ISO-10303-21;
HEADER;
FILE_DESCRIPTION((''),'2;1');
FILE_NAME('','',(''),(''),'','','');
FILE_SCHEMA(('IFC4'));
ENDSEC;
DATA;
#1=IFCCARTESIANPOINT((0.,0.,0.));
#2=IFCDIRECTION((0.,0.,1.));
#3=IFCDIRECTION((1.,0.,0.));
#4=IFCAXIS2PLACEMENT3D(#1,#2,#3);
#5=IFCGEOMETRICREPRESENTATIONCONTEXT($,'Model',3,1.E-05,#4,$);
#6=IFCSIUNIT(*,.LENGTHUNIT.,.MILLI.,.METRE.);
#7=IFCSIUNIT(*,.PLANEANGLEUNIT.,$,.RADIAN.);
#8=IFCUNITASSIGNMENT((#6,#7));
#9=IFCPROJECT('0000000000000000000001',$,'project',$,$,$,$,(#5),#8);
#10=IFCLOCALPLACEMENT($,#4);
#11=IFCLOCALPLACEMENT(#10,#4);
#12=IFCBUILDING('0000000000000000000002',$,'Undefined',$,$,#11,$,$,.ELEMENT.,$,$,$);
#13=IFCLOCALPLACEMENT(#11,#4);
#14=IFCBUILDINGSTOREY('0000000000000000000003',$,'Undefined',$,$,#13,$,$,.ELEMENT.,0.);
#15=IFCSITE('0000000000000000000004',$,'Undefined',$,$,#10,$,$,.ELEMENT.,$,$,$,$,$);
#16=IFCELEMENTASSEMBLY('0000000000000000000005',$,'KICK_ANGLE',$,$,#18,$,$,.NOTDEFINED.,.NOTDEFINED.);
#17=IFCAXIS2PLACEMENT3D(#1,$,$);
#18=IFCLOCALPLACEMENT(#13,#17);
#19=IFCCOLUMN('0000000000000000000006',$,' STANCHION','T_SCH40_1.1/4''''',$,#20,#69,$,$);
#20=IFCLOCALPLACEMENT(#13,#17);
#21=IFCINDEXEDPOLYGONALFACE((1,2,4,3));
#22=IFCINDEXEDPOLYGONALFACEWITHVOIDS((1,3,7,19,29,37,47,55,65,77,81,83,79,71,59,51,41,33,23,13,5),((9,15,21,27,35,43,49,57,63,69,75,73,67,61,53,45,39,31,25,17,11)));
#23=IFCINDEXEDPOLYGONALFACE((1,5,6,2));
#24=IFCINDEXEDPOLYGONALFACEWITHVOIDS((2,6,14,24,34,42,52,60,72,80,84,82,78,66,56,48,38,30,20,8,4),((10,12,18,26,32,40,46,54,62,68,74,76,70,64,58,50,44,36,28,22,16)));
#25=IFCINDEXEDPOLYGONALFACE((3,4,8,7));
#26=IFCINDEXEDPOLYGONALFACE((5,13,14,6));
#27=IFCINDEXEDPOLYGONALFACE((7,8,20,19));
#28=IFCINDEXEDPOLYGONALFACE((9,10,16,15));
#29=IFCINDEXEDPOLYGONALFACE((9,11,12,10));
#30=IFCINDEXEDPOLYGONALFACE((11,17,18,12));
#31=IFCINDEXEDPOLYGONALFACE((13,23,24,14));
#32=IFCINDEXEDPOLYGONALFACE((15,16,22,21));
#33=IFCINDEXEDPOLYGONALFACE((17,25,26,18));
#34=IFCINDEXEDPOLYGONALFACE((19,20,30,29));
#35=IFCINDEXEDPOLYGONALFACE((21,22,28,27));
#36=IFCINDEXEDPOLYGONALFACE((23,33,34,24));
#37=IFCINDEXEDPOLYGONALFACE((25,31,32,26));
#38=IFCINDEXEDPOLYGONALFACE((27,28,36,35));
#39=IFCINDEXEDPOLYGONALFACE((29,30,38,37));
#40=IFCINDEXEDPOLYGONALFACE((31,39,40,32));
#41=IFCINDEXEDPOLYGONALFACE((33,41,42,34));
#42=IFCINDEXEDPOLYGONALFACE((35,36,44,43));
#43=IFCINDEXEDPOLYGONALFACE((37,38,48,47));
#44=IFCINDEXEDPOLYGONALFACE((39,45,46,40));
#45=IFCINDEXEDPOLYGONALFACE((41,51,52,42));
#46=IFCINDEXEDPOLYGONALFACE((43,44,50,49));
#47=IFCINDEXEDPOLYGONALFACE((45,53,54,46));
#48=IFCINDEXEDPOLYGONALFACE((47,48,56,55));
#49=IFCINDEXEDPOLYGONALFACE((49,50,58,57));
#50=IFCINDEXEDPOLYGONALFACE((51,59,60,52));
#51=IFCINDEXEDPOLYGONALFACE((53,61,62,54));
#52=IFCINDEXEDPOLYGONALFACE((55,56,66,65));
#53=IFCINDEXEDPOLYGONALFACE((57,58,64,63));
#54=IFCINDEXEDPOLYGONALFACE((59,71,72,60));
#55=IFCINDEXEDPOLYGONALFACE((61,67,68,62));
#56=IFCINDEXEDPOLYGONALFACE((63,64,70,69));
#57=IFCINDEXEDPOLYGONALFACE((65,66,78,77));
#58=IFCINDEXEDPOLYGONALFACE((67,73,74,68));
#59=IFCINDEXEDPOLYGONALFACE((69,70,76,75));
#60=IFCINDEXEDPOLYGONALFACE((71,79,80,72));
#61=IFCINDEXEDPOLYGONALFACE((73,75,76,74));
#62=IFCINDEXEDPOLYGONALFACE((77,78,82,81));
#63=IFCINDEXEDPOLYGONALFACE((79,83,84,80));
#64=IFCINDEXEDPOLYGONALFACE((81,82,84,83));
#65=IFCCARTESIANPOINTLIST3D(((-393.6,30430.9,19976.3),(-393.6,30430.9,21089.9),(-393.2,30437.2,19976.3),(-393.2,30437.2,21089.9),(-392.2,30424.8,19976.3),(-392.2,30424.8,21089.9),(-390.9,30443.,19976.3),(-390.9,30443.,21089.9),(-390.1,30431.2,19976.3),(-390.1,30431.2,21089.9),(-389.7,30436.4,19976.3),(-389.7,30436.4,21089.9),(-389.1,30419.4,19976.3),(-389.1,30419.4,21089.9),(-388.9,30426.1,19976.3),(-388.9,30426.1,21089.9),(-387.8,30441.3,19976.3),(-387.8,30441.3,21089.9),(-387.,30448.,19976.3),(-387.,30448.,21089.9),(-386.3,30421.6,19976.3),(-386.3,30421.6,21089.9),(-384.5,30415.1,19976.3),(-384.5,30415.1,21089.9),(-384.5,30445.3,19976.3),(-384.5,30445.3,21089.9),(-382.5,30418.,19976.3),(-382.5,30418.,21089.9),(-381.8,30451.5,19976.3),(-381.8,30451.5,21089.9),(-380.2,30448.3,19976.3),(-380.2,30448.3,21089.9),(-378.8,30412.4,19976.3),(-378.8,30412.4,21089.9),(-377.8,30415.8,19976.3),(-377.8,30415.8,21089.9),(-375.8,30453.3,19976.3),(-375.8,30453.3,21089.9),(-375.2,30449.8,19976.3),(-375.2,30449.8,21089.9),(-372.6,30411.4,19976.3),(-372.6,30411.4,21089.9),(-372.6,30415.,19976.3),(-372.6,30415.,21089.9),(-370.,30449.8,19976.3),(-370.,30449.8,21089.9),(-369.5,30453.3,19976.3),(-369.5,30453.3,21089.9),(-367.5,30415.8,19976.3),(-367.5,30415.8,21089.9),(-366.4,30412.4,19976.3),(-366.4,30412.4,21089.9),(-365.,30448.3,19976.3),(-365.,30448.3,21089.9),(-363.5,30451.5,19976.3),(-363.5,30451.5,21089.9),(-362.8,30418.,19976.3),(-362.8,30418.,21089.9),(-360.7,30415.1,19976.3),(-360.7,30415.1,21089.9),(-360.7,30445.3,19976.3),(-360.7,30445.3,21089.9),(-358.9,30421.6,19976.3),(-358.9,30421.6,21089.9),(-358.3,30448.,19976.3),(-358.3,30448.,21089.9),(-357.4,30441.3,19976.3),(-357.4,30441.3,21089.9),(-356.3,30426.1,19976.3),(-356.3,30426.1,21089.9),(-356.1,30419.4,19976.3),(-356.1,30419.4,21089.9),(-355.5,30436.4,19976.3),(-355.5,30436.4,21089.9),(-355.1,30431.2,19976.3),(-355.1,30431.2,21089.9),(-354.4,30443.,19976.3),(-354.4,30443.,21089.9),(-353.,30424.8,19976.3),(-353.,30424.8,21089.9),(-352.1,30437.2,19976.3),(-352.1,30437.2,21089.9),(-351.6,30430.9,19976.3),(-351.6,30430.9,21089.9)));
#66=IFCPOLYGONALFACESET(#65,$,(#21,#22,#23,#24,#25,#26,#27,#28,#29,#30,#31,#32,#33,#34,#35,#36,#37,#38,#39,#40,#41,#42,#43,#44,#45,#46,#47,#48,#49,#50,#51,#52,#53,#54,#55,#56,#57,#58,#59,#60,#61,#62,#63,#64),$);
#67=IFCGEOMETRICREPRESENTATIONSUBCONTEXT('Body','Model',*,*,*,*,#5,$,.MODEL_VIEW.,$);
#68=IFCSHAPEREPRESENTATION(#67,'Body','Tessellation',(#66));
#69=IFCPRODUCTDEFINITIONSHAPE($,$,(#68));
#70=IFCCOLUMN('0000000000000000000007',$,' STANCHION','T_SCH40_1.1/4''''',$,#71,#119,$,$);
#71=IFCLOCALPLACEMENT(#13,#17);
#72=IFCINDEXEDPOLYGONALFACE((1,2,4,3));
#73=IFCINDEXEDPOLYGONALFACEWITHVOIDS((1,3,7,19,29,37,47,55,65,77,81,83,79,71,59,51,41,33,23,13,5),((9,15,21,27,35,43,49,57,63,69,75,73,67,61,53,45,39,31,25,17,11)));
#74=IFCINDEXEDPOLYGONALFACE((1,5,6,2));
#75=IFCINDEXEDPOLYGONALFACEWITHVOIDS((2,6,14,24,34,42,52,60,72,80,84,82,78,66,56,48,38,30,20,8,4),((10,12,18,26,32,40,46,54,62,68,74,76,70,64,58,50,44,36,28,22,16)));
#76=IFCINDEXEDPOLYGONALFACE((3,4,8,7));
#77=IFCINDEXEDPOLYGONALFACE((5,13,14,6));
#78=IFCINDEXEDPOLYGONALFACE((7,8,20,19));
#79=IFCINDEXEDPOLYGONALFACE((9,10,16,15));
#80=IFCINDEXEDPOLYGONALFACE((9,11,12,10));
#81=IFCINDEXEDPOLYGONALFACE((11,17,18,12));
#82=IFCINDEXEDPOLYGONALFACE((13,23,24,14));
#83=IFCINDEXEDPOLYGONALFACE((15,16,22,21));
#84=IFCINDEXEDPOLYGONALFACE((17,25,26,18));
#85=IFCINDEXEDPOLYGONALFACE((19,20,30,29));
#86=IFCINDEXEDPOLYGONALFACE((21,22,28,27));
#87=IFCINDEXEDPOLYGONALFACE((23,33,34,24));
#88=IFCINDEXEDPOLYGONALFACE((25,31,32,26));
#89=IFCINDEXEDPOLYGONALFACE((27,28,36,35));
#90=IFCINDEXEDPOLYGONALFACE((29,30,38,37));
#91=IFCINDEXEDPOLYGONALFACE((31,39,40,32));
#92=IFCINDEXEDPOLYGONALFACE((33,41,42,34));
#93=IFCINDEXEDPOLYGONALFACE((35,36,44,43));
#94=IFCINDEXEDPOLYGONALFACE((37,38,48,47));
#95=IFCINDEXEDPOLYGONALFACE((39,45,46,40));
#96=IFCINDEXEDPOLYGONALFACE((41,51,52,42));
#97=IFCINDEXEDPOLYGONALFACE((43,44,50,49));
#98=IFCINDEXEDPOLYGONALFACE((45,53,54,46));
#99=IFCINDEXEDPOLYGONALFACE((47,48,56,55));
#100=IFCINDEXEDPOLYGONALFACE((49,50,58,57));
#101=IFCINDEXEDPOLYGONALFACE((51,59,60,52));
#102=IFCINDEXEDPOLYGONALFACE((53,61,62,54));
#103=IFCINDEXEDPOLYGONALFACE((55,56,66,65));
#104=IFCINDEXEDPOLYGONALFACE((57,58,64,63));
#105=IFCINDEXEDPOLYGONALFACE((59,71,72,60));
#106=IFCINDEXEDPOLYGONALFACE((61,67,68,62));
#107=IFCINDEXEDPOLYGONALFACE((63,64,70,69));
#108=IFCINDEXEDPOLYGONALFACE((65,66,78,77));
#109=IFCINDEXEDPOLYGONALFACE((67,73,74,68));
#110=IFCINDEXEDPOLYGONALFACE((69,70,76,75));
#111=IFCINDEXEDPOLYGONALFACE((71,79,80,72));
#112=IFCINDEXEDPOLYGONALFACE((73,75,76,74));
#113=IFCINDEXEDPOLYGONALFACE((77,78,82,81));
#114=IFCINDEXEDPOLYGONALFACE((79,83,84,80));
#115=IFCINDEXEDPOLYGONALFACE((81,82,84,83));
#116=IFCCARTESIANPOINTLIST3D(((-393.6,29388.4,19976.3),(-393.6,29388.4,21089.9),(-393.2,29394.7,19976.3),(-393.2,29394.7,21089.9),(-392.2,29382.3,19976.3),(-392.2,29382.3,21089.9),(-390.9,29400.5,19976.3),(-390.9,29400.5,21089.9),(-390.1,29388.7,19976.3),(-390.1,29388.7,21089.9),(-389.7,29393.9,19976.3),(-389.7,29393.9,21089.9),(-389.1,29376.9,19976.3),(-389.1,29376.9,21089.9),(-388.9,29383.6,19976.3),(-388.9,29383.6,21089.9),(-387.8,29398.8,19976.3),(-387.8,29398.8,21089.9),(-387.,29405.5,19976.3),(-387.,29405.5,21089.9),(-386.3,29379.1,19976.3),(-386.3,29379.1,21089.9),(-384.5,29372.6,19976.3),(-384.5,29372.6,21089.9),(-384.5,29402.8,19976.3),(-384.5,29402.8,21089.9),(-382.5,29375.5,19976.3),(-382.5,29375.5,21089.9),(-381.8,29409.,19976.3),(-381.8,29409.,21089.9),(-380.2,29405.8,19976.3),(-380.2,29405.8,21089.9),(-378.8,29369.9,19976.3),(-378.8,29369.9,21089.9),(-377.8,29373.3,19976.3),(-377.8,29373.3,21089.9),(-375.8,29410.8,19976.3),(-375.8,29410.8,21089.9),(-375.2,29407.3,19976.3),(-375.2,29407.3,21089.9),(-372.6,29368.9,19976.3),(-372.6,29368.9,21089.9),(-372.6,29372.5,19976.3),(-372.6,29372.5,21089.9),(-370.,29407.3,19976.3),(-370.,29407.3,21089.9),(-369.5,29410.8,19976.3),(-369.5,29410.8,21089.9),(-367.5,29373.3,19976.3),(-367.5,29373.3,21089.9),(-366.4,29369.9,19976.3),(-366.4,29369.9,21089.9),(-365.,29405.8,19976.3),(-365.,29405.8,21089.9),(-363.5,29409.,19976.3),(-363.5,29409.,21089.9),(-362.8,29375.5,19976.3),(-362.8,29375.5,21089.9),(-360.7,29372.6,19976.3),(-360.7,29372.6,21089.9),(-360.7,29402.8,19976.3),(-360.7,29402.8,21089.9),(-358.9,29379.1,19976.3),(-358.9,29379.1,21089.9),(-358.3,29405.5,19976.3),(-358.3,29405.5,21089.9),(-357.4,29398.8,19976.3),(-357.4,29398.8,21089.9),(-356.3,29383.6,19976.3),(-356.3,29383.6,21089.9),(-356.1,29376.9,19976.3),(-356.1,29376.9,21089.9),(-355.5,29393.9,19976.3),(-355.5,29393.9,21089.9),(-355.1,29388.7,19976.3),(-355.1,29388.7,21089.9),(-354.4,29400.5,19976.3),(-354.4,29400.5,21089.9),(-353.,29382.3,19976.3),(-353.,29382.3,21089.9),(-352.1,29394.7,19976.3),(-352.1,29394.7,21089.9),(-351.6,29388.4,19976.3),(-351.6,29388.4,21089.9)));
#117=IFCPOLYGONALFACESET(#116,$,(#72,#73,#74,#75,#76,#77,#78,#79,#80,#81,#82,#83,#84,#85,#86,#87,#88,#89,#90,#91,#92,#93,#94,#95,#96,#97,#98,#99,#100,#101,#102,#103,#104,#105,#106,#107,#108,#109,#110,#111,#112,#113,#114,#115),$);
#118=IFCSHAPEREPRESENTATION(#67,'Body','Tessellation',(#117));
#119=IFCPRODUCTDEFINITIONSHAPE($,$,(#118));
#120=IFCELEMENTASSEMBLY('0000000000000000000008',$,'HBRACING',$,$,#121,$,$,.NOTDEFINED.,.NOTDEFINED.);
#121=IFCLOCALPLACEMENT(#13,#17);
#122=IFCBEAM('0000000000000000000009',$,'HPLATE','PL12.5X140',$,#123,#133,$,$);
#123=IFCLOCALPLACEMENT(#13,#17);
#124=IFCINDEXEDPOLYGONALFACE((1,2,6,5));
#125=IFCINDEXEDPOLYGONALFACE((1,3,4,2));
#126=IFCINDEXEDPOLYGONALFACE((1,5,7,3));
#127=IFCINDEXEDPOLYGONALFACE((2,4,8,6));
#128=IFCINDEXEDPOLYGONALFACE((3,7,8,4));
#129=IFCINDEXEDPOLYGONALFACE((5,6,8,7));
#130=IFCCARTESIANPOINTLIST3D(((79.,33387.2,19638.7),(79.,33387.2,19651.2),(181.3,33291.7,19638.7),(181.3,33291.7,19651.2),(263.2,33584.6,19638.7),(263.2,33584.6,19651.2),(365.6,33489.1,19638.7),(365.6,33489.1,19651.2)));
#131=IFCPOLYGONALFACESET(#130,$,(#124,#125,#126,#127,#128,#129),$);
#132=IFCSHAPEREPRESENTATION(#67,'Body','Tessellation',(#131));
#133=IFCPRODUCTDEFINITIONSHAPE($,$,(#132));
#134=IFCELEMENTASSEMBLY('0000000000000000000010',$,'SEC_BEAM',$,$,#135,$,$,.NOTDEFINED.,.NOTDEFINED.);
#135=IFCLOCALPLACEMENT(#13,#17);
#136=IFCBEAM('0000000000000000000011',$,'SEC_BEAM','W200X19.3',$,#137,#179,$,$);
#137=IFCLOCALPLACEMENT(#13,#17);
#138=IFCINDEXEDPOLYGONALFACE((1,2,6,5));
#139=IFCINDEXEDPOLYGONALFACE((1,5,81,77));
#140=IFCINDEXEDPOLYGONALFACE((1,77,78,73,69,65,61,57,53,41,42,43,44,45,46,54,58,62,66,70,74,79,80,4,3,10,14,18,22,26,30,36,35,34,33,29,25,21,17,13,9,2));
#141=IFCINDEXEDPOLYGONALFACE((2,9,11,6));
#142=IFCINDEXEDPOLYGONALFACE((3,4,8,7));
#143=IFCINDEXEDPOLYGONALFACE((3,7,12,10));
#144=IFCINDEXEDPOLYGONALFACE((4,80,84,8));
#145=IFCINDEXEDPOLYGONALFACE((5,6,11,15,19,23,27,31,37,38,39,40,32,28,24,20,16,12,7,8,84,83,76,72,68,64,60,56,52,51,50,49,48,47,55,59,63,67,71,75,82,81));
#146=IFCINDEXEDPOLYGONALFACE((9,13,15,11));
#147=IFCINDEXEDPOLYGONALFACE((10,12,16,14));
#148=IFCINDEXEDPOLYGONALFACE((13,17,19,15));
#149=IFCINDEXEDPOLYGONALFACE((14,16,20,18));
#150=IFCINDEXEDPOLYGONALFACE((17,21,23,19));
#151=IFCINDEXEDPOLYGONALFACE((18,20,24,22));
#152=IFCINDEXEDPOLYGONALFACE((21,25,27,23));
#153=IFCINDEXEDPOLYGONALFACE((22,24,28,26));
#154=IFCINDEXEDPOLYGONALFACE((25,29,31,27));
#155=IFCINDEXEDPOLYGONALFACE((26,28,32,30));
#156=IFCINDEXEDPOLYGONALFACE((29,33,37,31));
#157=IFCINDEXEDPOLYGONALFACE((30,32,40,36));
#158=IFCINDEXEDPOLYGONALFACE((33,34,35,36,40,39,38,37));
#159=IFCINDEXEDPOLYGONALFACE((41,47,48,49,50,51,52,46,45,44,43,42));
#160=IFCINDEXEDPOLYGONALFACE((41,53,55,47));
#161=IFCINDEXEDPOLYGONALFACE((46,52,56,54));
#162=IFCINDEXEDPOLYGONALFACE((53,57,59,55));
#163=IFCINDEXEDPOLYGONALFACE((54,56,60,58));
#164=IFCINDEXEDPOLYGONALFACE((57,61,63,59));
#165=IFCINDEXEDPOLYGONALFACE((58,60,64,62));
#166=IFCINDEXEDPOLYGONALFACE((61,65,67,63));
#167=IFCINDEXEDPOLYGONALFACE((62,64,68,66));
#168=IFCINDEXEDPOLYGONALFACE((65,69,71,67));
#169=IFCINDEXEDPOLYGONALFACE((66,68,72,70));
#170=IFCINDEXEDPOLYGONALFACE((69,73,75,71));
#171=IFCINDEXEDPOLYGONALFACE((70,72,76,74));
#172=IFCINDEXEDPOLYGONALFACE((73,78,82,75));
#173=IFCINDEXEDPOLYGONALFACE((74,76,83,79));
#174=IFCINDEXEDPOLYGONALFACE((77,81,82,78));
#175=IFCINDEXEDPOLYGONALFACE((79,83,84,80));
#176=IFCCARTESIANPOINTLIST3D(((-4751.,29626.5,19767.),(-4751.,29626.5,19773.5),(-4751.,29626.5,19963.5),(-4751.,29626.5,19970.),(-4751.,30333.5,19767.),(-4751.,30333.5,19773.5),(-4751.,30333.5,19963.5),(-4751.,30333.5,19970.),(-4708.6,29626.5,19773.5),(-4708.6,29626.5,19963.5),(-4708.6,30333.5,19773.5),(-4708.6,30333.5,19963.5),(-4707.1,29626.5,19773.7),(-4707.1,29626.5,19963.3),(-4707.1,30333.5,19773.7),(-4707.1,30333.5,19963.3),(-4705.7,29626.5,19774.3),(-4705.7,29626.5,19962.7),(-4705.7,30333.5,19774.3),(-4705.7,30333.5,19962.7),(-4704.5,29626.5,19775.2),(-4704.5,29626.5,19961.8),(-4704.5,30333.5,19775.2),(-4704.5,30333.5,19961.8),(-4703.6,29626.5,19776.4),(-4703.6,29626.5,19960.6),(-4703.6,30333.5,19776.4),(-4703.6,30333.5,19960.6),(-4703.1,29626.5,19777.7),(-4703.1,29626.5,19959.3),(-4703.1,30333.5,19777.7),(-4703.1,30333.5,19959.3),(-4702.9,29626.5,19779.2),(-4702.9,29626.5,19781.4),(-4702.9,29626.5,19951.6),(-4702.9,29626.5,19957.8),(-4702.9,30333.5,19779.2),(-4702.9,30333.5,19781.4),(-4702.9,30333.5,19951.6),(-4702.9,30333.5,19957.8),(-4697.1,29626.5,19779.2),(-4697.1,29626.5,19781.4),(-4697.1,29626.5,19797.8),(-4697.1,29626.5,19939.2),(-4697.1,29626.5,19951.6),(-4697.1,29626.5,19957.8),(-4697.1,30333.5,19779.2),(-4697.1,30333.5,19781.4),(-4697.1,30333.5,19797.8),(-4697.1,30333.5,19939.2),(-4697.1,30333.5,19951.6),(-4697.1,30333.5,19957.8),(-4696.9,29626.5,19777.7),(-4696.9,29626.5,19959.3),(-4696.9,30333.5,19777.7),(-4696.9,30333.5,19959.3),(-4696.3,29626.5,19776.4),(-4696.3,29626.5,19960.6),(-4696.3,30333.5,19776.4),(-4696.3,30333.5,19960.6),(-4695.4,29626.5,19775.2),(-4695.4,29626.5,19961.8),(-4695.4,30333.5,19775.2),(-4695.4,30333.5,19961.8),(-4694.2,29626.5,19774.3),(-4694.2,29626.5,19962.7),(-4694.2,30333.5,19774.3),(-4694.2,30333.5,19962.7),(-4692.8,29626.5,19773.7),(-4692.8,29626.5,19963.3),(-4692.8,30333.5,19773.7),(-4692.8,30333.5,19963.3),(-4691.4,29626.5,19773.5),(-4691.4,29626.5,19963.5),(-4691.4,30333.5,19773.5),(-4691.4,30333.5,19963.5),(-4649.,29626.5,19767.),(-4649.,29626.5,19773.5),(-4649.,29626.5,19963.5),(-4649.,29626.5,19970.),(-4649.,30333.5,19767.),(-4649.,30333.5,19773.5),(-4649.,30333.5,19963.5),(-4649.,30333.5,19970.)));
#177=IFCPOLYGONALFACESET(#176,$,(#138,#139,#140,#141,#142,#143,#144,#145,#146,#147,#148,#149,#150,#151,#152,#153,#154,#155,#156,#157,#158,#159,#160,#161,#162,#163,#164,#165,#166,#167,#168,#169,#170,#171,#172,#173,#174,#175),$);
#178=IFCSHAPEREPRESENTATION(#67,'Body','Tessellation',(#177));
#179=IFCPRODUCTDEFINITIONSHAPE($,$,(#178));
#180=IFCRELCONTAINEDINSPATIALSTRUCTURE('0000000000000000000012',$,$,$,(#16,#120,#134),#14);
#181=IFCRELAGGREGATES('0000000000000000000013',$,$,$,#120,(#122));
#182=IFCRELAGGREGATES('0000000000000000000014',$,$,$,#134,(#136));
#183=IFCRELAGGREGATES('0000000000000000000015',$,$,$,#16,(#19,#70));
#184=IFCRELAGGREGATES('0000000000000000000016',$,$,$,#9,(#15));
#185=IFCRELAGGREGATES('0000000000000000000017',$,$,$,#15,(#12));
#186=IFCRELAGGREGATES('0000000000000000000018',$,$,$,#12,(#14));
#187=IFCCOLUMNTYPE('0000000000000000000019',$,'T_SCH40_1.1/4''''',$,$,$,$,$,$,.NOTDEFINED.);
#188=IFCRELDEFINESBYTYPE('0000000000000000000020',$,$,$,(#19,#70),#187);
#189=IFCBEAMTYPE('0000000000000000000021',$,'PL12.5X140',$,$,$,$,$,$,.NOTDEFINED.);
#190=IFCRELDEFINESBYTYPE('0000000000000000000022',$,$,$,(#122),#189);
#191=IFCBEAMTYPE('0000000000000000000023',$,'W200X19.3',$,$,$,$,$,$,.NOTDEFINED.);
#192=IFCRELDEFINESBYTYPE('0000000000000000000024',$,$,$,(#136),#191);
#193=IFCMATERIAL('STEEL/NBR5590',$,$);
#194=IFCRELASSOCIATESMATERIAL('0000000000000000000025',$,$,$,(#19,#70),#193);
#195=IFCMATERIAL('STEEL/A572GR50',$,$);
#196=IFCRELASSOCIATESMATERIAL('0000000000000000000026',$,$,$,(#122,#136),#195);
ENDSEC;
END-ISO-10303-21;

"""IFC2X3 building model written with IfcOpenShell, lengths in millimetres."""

from ifc_helpers import new_model, si_unit, frame, origin_with_axes, origin_2d_with_axis, place, context, subcontext, project, spatial, polyline, rectangle, hollow_circle, i_section, outline, extrude, boolean, halfspace, material, type_object, element, aggregate, save


model = new_model("IFC2X3")

# Units and contexts
model_context = context("Model", 3, precision=1e-05, world=origin_with_axes())
body_context = subcontext(model_context, "Body", "Model", "MODEL_VIEW")
ifc_project = project(units=[si_unit("LENGTHUNIT", "METRE", prefix="MILLI"), si_unit("PLANEANGLEUNIT", "RADIAN")], contexts=[model_context])

# Site, building, storey
site_placement = place(None, origin_with_axes())
site = spatial("IfcSite", under=ifc_project, at=site_placement, Name="Undefined", CompositionType="ELEMENT")
building_placement = place(site_placement, origin_with_axes())
building = spatial("IfcBuilding", under=site, at=building_placement, Name="Undefined", CompositionType="ELEMENT")
storey_placement = place(building_placement, origin_with_axes())
storey = spatial("IfcBuildingStorey", under=building, at=storey_placement, Name="Undefined", CompositionType="ELEMENT", Elevation=0.0)

# Shared definitions
ifc_material_1 = material(Name="STEEL/NBR5590")
column_type = type_object("IfcColumnType", Name="T_SCH40_1.1/4''", PredefinedType="NOTDEFINED")

# Element assembly, columns
assembly_1_placement = place(storey_placement, origin_with_axes())
assembly_1 = element("IfcElementAssembly", 1, at=assembly_1_placement, inside=storey, Name="KICK_ANGLE", AssemblyPlace="NOTDEFINED", PredefinedType="NOTDEFINED")
column_1_placement = place(assembly_1_placement, frame((-372.6, 30432.5, 19976.3), z_axis=(0.0, 0.0, 1.0), x_axis=(-1.0, 0.0, 0.0)))
column_1 = element("IfcColumn", 2, at=column_1_placement, type_object=column_type, material=ifc_material_1, Name=" STANCHION", Description="T_SCH40_1.1/4''", context=body_context, shape_type="SweptSolid", body=[
    extrude(hollow_circle(Radius=21.1, WallThickness=3.6, at=origin_2d_with_axis()), frame((0.0, 0.0, 1113.6), z_axis=(0.0, 0.0, -1.0), x_axis=(0.0, 1.0, 0.0)), (0.0, 0.0, 1.0), 1113.6),
])
column_2_placement = place(assembly_1_placement, frame((-372.6, 29390.0, 19976.3), z_axis=(0.0, 0.0, 1.0), x_axis=(-1.0, 0.0, 0.0)))
column_2 = element("IfcColumn", 3, at=column_2_placement, type_object=column_type, material=ifc_material_1, Name=" STANCHION", Description="T_SCH40_1.1/4''", context=body_context, shape_type="SweptSolid", body=[
    extrude(hollow_circle(Radius=21.1, WallThickness=3.6, at=origin_2d_with_axis()), frame((0.0, 0.0, 1113.6), z_axis=(0.0, 0.0, -1.0), x_axis=(0.0, 1.0, 0.0)), (0.0, 0.0, 1.0), 1113.6),
])

# Element assemblies, beams
assembly_2_placement = place(storey_placement, origin_with_axes())
assembly_2 = element("IfcElementAssembly", 4, at=assembly_2_placement, inside=storey, Name="HBRACING", AssemblyPlace="NOTDEFINED", PredefinedType="NOTDEFINED")
ifc_material_2 = material(Name="STEEL/A572GR50")
beam_type_1 = type_object("IfcBeamType", Name="PL12.5X140", PredefinedType="NOTDEFINED")
beam_1_placement = place(assembly_2_placement, frame((130.2, 33339.5, 19645.0), z_axis=(0.731055, -0.682318, 0.0), x_axis=(0.682318, 0.731055, 0.0)))
beam_1 = element("IfcBeam", 5, at=beam_1_placement, type_object=beam_type_1, material=ifc_material_2, Name="HPLATE", Description="PL12.5X140", context=body_context, shape_type="SweptSolid", body=[
    extrude(rectangle(XDim=12.5, YDim=140.0, at=origin_2d_with_axis()), frame((270.0, 0.0, 0.0), z_axis=(-1.0, 0.0, 0.0), x_axis=(0.0, -1.0, 0.0)), (0.0, 0.0, 1.0), 270.0),
])
assembly_3_placement = place(storey_placement, origin_with_axes())
assembly_3 = element("IfcElementAssembly", 6, at=assembly_3_placement, inside=storey, Name="SEC_BEAM", AssemblyPlace="NOTDEFINED", PredefinedType="NOTDEFINED")
beam_type_2 = type_object("IfcBeamType", Name="W200X19.3", PredefinedType="NOTDEFINED")
beam_2_placement = place(assembly_3_placement, frame((-4700.0, 30410.0, 19868.5), z_axis=(0.0, 0.0, 1.0), x_axis=(0.0, -1.0, 0.0)))
beam_2 = element("IfcBeam", 7, at=beam_2_placement, type_object=beam_type_2, material=ifc_material_2, Name="SEC_BEAM", Description="W200X19.3", context=body_context, shape_type="CSG", body=[
    boolean("DIFFERENCE", boolean("DIFFERENCE", boolean("DIFFERENCE", boolean("DIFFERENCE", boolean("DIFFERENCE", boolean("DIFFERENCE", boolean("DIFFERENCE", boolean("DIFFERENCE", extrude(i_section(OverallWidth=102.0, OverallDepth=203.0, WebThickness=5.8, FlangeThickness=6.5, FilletRadius=5.7, at=origin_2d_with_axis()), frame((860.0, 0.0, 0.0), z_axis=(-1.0, 0.0, 0.0), x_axis=(0.0, -1.0, 0.0)), (0.0, 0.0, 1.0), 860.0), extrude(outline(polyline([(0.0, 0.0), (24.4, 0.0), (24.4, 10.0), (0.0, 10.0), (0.0, 0.0)])), frame((783.5, 61.0, -87.1), z_axis=(0.0, -1.0, 0.0), x_axis=(0.0, 0.0, -1.0)), (0.0, 0.0, 1.0), 122.0)), extrude(outline(polyline([(0.0, 0.0), (28.4, 0.0), (28.4, 10.0), (0.0, 10.0), (0.0, 0.0)])), frame((783.5, -61.0, 83.1), z_axis=(0.0, 1.0, 0.0), x_axis=(0.0, 0.0, 1.0)), (0.0, 0.0, 1.0), 122.0)), extrude(rectangle(XDim=143.6, YDim=143.6, at=origin_2d_with_axis()), frame((785.3, 74.7, 70.7), z_axis=(0.0, 0.0, -1.0), x_axis=(-1.0, 0.0, 0.0)), (0.0, 0.0, 1.0), 141.5)), extrude(outline(polyline([(0.0, 0.0), (28.4, 0.0), (28.4, 10.0), (0.0, 10.0), (0.0, 0.0)])), frame((76.5, 61.0, 83.1), z_axis=(0.0, -1.0, 0.0), x_axis=(0.0, 0.0, 1.0)), (0.0, 0.0, 1.0), 122.0)), extrude(outline(polyline([(0.0, 0.0), (24.4, 0.0), (24.4, 10.0), (0.0, 10.0), (0.0, 0.0)])), frame((76.5, -61.0, -87.1), z_axis=(0.0, 1.0, 0.0), x_axis=(0.0, 0.0, -1.0)), (0.0, 0.0, 1.0), 122.0)), extrude(rectangle(XDim=143.6, YDim=143.6, at=origin_2d_with_axis()), frame((74.7, 74.7, 70.7), z_axis=(0.0, 0.0, -1.0), x_axis=(1.0, 0.0, 0.0)), (0.0, 0.0, 1.0), 141.5)), halfspace(frame((783.5, 0.0, 201.5), z_axis=(1.0, 0.0, 0.0), x_axis=(0.0, 1.0, 0.0)), False)), halfspace(frame((76.5, 0.0, 201.5), z_axis=(-1.0, 0.0, 0.0), x_axis=(0.0, -1.0, 0.0)), False)),
])

aggregate(assembly_2, [beam_1])

aggregate(assembly_3, [beam_2])
aggregate(assembly_1, [column_1, column_2])

save(model, "model.ifc")
